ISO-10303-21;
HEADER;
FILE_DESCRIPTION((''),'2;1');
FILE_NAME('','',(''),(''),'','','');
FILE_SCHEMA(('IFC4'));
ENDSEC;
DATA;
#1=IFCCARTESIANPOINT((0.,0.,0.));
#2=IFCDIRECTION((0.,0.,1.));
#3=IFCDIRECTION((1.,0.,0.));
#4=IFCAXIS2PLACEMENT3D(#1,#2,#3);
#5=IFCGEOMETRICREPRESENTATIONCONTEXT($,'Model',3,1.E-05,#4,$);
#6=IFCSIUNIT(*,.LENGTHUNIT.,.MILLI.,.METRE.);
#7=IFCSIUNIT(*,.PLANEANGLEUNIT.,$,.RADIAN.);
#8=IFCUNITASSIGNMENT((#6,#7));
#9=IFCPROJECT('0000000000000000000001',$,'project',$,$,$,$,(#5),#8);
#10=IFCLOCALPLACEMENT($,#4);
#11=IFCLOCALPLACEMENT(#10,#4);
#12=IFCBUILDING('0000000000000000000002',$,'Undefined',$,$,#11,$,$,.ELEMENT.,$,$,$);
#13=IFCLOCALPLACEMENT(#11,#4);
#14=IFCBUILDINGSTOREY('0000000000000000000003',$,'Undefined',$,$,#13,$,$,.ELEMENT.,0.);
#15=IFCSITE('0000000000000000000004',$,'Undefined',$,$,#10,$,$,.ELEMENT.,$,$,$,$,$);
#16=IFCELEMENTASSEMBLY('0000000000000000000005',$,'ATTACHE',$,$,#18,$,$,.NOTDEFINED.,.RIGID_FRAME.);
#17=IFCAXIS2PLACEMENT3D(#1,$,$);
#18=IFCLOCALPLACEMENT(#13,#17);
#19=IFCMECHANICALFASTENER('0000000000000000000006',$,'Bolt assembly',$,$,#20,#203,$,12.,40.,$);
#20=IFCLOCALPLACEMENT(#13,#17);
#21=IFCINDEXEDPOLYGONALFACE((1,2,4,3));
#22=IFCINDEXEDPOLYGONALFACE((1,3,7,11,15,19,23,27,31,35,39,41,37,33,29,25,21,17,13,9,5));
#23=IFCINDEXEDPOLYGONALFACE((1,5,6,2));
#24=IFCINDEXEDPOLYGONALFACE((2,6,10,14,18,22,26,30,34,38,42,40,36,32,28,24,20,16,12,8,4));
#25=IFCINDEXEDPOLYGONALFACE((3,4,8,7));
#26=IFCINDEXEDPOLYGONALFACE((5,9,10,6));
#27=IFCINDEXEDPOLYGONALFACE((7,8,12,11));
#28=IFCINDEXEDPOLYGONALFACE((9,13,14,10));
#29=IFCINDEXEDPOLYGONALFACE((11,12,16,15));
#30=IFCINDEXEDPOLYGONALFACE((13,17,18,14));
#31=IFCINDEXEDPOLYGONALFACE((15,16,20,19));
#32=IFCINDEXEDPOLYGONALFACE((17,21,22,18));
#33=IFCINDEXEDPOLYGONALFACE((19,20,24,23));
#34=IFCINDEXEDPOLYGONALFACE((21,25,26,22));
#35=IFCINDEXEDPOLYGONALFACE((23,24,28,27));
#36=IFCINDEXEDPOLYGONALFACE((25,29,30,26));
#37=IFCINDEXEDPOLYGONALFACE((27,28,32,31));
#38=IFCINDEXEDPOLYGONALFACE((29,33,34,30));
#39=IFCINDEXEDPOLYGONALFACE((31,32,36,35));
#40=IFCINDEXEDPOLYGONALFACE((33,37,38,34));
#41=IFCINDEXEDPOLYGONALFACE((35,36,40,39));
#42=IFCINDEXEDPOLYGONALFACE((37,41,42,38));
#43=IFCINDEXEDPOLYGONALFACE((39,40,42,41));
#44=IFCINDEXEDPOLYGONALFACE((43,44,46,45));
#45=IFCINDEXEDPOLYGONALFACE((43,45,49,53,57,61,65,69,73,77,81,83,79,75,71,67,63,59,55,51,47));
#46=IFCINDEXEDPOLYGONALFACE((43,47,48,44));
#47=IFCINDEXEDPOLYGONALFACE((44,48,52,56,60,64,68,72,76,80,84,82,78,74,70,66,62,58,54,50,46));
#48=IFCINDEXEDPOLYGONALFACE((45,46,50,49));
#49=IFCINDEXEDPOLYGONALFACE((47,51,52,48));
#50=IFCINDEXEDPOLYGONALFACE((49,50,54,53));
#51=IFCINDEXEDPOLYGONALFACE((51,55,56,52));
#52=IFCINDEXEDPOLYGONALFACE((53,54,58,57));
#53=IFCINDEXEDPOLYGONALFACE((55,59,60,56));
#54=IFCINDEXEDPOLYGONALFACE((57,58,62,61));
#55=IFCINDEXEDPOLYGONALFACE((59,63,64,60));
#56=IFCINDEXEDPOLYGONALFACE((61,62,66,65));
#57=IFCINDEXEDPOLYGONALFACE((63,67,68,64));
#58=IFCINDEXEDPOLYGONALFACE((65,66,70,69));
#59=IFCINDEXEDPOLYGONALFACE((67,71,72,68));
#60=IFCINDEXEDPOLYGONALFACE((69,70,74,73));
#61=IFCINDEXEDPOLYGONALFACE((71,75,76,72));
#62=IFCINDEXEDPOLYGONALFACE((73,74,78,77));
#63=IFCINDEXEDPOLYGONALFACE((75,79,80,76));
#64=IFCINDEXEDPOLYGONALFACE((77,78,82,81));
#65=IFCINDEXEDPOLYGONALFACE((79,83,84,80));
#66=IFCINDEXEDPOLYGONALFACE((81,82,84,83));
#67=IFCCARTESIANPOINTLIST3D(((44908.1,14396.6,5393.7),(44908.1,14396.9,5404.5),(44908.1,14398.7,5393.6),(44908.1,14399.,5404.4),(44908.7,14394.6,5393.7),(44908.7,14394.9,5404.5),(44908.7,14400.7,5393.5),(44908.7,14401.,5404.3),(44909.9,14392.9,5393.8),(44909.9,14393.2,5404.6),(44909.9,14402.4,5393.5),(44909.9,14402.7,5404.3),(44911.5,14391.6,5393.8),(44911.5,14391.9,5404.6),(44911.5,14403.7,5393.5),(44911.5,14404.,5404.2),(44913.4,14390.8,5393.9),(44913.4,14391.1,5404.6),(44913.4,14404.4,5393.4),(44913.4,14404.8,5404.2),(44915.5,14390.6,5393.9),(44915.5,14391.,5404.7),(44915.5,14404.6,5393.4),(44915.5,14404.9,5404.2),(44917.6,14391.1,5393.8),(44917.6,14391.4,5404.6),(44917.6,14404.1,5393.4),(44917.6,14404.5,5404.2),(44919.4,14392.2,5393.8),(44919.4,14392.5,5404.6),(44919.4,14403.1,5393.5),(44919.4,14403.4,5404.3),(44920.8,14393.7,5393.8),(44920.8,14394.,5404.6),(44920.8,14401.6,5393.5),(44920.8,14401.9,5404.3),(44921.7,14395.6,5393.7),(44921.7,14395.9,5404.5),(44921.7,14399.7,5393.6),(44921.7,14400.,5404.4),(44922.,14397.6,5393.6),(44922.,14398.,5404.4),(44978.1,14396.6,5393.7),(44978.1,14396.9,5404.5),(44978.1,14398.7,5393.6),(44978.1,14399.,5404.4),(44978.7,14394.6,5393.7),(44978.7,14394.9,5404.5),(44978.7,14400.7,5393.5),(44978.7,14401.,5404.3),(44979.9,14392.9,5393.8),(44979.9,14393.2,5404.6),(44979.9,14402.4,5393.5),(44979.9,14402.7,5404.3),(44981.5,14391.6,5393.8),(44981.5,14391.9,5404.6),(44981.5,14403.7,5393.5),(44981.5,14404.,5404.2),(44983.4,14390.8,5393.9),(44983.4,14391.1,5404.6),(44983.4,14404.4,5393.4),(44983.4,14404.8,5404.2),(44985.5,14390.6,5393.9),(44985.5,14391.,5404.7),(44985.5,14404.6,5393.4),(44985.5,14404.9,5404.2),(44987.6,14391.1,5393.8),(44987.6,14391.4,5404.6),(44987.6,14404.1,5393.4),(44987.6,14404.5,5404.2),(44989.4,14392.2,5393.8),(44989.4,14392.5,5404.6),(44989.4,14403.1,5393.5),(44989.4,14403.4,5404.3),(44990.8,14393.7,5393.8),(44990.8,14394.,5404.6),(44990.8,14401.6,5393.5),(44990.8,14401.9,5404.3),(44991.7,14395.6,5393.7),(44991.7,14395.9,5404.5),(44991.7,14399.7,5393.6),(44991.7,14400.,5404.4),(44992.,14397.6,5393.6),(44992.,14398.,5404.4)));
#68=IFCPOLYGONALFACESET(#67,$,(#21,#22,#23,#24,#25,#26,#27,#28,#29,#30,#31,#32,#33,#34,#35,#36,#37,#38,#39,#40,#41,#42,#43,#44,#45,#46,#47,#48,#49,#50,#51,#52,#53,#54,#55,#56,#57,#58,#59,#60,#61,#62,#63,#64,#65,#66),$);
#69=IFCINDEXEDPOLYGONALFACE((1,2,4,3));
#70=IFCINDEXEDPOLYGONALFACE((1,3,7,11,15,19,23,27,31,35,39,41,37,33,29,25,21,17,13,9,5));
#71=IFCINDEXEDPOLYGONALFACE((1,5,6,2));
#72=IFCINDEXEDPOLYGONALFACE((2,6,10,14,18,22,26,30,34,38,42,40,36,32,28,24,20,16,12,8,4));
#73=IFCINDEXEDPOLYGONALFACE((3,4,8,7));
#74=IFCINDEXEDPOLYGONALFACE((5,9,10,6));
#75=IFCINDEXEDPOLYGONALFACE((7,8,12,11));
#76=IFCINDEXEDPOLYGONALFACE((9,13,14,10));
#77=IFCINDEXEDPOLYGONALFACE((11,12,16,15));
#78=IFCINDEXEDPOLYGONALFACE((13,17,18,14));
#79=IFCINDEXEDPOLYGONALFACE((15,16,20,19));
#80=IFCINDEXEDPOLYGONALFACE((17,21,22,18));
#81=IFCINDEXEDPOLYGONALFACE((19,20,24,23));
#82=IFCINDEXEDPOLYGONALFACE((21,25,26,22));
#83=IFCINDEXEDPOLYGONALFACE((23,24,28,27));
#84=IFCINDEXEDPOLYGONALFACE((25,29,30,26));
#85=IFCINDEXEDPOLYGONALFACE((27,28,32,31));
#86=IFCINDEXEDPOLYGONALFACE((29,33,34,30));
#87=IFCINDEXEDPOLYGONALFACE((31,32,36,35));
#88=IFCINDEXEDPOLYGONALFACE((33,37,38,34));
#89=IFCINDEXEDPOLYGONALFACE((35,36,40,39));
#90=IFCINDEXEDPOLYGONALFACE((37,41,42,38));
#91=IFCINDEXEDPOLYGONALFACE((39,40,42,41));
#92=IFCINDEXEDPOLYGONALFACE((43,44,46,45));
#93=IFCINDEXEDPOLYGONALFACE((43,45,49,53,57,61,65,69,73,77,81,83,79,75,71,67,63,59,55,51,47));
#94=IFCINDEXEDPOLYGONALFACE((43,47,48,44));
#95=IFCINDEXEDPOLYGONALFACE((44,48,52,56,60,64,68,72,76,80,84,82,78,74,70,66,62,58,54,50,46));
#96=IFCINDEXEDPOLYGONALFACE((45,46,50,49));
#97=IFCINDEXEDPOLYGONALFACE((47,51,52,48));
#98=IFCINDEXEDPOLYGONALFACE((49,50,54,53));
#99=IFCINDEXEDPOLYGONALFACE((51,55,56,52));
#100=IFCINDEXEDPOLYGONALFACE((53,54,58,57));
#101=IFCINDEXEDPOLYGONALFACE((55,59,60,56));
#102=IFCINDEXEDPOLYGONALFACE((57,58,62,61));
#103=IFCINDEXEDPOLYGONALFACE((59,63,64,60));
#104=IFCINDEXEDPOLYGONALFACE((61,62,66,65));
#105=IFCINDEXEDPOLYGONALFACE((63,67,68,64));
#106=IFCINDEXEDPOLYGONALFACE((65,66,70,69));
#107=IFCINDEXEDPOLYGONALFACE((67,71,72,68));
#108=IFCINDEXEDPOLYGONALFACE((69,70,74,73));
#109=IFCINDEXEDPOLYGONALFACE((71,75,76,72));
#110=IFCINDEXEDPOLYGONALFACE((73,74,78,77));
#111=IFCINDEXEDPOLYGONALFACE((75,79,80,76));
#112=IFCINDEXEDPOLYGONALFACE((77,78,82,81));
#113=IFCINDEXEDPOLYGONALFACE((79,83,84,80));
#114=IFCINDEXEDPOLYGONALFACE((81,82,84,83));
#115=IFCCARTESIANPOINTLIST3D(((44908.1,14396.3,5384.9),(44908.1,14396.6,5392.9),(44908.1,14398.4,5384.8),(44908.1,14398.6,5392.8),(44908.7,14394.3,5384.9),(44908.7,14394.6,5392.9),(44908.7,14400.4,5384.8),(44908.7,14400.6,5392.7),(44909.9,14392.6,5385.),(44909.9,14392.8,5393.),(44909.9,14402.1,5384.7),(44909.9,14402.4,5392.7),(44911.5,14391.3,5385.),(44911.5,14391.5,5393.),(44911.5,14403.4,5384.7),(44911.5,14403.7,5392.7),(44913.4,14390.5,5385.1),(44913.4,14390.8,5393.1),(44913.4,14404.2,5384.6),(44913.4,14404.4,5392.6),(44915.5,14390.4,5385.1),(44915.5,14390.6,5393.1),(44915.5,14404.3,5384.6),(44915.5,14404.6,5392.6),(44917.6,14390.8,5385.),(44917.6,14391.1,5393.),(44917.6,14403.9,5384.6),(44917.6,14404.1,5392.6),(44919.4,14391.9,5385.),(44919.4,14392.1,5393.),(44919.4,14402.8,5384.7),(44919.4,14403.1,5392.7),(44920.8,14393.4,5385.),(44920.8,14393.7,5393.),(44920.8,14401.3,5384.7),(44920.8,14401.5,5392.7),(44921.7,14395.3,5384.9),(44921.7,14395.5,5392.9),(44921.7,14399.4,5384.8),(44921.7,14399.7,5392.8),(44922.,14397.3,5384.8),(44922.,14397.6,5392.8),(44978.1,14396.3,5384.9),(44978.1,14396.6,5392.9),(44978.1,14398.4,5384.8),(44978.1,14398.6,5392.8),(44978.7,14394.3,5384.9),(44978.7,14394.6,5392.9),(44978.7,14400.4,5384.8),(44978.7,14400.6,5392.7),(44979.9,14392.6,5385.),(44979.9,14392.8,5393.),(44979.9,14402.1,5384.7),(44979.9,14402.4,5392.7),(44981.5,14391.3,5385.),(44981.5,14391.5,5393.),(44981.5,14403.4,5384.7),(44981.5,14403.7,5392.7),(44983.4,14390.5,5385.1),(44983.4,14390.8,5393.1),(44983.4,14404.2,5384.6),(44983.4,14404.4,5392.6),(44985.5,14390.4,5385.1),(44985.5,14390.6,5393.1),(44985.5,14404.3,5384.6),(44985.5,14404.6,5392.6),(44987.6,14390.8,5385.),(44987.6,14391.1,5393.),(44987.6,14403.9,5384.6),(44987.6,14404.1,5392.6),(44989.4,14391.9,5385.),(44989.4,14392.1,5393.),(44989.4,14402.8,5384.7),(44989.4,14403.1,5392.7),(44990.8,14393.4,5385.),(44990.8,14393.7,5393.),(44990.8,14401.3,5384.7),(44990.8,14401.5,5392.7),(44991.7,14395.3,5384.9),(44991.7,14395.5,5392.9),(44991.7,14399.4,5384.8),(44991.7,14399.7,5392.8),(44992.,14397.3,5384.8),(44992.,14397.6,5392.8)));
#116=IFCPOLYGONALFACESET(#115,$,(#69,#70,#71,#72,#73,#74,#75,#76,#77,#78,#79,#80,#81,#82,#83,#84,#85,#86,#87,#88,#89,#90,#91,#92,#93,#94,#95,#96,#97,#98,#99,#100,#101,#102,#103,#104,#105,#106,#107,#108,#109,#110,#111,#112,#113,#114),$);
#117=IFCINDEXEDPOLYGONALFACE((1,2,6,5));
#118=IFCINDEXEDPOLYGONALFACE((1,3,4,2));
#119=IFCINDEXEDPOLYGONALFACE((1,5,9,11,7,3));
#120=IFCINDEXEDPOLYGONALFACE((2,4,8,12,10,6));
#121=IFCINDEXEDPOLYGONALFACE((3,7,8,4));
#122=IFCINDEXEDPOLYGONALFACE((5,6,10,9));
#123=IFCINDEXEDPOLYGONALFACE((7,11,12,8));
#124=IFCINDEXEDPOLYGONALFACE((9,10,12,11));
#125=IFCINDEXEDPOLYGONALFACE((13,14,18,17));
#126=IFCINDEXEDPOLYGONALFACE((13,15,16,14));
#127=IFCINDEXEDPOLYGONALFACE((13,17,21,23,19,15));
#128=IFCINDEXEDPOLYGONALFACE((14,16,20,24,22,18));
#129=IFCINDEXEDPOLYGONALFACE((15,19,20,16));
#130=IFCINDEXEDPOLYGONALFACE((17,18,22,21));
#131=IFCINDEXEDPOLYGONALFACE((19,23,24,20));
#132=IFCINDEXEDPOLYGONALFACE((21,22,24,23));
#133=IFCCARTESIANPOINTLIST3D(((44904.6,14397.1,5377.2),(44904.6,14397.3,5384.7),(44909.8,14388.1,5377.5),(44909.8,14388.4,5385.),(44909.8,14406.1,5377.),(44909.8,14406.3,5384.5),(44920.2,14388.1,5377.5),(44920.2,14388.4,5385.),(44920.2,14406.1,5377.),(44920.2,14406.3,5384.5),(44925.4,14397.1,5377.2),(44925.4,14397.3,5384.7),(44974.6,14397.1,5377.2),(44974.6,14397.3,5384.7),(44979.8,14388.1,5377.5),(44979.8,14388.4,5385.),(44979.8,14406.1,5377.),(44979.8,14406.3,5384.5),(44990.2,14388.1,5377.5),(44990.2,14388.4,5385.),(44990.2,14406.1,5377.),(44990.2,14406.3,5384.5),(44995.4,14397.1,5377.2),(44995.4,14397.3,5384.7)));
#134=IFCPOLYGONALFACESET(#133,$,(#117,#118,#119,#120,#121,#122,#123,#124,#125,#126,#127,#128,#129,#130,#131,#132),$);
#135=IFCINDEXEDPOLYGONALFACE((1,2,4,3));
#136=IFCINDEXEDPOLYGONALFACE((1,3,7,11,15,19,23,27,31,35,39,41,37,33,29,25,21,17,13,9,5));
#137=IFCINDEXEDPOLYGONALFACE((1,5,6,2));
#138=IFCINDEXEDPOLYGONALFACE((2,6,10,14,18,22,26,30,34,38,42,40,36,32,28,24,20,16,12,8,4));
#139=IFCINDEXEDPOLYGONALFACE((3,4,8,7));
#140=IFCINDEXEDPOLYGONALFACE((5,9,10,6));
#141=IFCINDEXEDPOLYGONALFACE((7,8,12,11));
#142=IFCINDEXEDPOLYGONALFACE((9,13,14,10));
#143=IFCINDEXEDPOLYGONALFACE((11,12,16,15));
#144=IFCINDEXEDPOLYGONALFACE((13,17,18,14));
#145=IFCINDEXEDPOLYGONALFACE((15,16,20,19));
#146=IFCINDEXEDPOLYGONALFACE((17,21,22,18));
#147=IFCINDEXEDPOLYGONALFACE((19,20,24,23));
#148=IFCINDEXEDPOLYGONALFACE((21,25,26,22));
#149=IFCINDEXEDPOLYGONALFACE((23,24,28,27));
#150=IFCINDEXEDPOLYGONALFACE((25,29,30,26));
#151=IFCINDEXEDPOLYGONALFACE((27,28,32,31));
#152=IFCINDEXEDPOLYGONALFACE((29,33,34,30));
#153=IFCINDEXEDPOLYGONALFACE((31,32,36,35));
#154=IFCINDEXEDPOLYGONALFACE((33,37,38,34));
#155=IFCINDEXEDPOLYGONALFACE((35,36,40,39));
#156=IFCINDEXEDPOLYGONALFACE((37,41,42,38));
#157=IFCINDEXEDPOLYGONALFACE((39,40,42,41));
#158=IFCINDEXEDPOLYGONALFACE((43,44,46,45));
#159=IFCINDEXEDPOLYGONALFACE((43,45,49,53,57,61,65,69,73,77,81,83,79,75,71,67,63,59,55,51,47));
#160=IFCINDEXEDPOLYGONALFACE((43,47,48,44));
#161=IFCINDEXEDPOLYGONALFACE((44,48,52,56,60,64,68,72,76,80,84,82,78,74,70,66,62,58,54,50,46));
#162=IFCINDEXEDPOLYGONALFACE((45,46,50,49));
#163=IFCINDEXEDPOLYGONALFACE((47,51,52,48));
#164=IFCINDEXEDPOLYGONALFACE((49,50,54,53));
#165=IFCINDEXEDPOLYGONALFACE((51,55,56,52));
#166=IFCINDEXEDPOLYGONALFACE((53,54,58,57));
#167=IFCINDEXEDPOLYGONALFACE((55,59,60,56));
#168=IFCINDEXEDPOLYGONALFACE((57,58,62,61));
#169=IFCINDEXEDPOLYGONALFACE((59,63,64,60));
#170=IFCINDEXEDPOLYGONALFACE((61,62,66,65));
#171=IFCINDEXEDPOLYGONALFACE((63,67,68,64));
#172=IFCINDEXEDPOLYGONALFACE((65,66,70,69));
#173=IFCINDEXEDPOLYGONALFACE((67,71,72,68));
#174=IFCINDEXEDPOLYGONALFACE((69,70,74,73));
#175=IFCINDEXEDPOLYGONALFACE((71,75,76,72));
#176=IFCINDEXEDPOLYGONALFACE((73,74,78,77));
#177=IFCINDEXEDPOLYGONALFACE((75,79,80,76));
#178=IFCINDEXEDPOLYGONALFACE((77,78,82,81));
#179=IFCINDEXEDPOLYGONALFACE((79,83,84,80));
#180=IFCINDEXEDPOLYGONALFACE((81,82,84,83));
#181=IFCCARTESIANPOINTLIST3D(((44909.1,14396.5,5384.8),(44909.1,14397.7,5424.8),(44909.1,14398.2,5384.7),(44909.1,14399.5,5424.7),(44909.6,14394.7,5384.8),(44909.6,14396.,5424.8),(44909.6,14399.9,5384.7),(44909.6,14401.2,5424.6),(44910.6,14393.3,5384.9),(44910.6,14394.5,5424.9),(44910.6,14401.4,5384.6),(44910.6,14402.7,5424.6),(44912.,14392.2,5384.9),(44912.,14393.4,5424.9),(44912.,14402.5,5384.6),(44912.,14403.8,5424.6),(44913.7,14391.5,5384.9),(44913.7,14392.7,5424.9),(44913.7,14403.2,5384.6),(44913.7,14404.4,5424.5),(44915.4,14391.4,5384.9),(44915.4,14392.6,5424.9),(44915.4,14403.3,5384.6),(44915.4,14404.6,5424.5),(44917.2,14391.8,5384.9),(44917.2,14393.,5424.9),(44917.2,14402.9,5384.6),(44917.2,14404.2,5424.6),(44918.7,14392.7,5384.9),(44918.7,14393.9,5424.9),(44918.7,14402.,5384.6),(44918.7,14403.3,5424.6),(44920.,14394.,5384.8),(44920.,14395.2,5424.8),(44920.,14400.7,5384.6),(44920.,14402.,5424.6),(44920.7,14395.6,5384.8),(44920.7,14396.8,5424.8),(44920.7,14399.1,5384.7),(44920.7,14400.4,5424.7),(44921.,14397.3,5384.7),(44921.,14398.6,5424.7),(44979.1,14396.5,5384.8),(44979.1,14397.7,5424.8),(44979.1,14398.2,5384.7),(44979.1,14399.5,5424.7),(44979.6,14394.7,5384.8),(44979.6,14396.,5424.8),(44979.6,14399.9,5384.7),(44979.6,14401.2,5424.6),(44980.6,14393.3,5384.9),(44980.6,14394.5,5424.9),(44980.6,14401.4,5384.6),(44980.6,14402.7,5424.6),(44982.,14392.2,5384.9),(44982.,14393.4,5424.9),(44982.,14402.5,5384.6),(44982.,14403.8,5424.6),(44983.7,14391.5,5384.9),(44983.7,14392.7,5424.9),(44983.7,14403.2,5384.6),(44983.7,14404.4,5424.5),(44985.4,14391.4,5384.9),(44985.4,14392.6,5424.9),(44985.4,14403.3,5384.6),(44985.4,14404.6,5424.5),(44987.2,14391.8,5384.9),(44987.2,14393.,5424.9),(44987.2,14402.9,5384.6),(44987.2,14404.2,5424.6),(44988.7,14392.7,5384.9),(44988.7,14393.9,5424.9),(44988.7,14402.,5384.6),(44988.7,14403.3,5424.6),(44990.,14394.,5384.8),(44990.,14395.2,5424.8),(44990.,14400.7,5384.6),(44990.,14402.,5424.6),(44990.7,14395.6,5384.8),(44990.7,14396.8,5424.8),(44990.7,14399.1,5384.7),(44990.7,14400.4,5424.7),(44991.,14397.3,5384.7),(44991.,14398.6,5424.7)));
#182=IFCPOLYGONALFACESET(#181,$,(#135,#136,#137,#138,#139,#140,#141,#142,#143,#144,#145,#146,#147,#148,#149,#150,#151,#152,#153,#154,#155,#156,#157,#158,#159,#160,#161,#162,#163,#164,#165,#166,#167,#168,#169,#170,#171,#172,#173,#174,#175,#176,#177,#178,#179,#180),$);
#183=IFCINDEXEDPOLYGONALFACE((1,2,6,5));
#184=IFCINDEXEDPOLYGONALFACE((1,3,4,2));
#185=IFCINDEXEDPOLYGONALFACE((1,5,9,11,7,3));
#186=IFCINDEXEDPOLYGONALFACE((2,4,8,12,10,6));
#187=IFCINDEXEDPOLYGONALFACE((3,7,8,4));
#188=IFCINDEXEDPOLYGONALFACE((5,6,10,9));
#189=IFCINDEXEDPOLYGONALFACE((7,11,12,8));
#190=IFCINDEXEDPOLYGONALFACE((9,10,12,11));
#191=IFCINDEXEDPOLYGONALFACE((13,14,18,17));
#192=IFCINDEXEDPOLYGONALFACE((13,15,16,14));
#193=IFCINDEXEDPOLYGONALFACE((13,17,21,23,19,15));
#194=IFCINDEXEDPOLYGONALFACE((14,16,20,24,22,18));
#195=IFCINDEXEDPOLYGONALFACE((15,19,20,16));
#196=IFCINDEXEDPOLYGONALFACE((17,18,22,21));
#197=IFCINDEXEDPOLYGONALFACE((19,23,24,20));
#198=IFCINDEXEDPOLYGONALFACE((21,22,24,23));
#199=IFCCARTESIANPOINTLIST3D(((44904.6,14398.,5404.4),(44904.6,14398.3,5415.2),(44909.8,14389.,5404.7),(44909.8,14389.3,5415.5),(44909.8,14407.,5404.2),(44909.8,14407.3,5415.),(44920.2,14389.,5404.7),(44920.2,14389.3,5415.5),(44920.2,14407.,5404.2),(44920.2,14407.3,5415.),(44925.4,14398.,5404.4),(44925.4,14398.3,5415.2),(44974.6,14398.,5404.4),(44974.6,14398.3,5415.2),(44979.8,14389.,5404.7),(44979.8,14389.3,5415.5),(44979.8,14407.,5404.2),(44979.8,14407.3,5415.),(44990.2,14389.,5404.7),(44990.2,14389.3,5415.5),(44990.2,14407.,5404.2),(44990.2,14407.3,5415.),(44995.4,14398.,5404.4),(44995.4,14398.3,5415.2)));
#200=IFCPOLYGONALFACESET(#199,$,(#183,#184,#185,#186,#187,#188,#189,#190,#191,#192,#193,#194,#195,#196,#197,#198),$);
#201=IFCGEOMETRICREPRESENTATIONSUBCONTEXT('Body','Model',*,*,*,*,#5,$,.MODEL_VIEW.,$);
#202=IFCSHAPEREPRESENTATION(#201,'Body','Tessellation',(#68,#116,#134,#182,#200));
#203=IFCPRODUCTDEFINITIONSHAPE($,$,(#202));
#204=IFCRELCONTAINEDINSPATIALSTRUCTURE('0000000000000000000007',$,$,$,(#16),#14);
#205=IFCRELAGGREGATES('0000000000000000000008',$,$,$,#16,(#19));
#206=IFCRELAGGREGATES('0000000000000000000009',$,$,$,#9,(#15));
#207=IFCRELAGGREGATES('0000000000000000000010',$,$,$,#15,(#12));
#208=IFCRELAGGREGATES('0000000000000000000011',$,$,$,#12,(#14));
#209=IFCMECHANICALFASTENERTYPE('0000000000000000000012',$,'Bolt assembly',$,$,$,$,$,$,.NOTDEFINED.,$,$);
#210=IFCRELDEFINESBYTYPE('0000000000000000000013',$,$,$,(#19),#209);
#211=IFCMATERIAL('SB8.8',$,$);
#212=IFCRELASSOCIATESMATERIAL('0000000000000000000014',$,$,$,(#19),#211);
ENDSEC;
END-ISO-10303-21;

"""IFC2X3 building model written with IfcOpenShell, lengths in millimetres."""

from ifc_helpers import new_model, si_unit, frame, origin_with_axes, origin_2d_with_axis, place, context, subcontext, project, spatial, polyline, circle, outline, extrude, source, transform, mapped, material, type_object, element, aggregate, save


model = new_model("IFC2X3")

# Units and contexts
model_context = context("Model", 3, precision=1e-05, world=origin_with_axes())
body_context = subcontext(model_context, "Body", "Model", "MODEL_VIEW")
ifc_project = project(units=[si_unit("LENGTHUNIT", "METRE", prefix="MILLI"), si_unit("PLANEANGLEUNIT", "RADIAN")], contexts=[model_context])

# Site, building, storey
site_placement = place(None, origin_with_axes())
site = spatial("IfcSite", under=ifc_project, at=site_placement, Name="Undefined", CompositionType="ELEMENT")
building_placement = place(site_placement, origin_with_axes())
building = spatial("IfcBuilding", under=site, at=building_placement, Name="Undefined", CompositionType="ELEMENT")
storey_placement = place(building_placement, origin_with_axes())
storey = spatial("IfcBuildingStorey", under=building, at=storey_placement, Name="Undefined", CompositionType="ELEMENT", Elevation=0.0)

# Shared definitions
ifc_material_1 = material(Name="SB8.8")
mechanical_fastener_type = type_object("IfcMechanicalFastenerType", Name="Bolt assembly")

# Element assembly, mechanical fastener
assembly_1_placement = place(storey_placement, origin_with_axes())
assembly_1 = element("IfcElementAssembly", 1, at=assembly_1_placement, inside=storey, Name="ATTACHE", AssemblyPlace="NOTDEFINED", PredefinedType="RIGID_FRAME")
shared_shape_1 = source(origin_with_axes(), body_context, "Body", "SweptSolid", [
    extrude(circle(Radius=7.0, at=origin_2d_with_axis()), frame((0.0, -0.1, 0.0), z_axis=(0.0, 1.0, 0.0), x_axis=(1.0, 0.0, 0.0)), (0.0, 0.0, 1.0), 10.8),
    extrude(circle(Radius=7.0, at=origin_2d_with_axis()), frame((0.0, -8.9, 0.0), z_axis=(0.0, 1.0, 0.0), x_axis=(1.0, 0.0, 0.0)), (0.0, 0.0, 1.0), 8.0),
    extrude(outline(polyline([(10.4, 0.0), (5.2, 9.0), (-5.2, 9.0), (-10.4, 0.0), (-5.2, -9.0), (5.2, -9.0), (10.4, 0.0)])), frame((0.0, -16.5, 0.0), z_axis=(0.0, 1.0, 0.0), x_axis=(1.0, 0.0, 0.0)), (0.0, 0.0, 1.0), 7.5),
    extrude(circle(Radius=6.0, at=origin_2d_with_axis()), frame((0.0, -9.0, 0.0), z_axis=(0.0, 1.0, 0.0), x_axis=(1.0, 0.0, 0.0)), (0.0, 0.0, 1.0), 40.0),
    extrude(outline(polyline([(10.4, 0.0), (5.2, 9.0), (-5.2, 9.0), (-10.4, 0.0), (-5.2, -9.0), (5.2, -9.0), (10.4, 0.0)])), frame((0.0, 10.7, 0.0), z_axis=(0.0, 1.0, 0.0), x_axis=(1.0, 0.0, 0.0)), (0.0, 0.0, 1.0), 10.8),
])
mechanical_fastener_1_placement = place(assembly_1_placement, frame((44915.0, 14397.6, 5393.7), z_axis=(0.0, -0.99952, 0.030986), x_axis=(1.0, 0.0, 0.0)))
mechanical_fastener_1 = element("IfcMechanicalFastener", 2, at=mechanical_fastener_1_placement, type_object=mechanical_fastener_type, material=ifc_material_1, Name="Bolt assembly", NominalDiameter=12.0, NominalLength=40.0, context=body_context, shape_type="MappedRepresentation", body=[
    mapped(shared_shape_1, transform((0.0, 0.0, 0.0))),
    mapped(shared_shape_1, transform((70.0, 0.0, 0.0))),
])
aggregate(assembly_1, [mechanical_fastener_1])

save(model, "model.ifc")
